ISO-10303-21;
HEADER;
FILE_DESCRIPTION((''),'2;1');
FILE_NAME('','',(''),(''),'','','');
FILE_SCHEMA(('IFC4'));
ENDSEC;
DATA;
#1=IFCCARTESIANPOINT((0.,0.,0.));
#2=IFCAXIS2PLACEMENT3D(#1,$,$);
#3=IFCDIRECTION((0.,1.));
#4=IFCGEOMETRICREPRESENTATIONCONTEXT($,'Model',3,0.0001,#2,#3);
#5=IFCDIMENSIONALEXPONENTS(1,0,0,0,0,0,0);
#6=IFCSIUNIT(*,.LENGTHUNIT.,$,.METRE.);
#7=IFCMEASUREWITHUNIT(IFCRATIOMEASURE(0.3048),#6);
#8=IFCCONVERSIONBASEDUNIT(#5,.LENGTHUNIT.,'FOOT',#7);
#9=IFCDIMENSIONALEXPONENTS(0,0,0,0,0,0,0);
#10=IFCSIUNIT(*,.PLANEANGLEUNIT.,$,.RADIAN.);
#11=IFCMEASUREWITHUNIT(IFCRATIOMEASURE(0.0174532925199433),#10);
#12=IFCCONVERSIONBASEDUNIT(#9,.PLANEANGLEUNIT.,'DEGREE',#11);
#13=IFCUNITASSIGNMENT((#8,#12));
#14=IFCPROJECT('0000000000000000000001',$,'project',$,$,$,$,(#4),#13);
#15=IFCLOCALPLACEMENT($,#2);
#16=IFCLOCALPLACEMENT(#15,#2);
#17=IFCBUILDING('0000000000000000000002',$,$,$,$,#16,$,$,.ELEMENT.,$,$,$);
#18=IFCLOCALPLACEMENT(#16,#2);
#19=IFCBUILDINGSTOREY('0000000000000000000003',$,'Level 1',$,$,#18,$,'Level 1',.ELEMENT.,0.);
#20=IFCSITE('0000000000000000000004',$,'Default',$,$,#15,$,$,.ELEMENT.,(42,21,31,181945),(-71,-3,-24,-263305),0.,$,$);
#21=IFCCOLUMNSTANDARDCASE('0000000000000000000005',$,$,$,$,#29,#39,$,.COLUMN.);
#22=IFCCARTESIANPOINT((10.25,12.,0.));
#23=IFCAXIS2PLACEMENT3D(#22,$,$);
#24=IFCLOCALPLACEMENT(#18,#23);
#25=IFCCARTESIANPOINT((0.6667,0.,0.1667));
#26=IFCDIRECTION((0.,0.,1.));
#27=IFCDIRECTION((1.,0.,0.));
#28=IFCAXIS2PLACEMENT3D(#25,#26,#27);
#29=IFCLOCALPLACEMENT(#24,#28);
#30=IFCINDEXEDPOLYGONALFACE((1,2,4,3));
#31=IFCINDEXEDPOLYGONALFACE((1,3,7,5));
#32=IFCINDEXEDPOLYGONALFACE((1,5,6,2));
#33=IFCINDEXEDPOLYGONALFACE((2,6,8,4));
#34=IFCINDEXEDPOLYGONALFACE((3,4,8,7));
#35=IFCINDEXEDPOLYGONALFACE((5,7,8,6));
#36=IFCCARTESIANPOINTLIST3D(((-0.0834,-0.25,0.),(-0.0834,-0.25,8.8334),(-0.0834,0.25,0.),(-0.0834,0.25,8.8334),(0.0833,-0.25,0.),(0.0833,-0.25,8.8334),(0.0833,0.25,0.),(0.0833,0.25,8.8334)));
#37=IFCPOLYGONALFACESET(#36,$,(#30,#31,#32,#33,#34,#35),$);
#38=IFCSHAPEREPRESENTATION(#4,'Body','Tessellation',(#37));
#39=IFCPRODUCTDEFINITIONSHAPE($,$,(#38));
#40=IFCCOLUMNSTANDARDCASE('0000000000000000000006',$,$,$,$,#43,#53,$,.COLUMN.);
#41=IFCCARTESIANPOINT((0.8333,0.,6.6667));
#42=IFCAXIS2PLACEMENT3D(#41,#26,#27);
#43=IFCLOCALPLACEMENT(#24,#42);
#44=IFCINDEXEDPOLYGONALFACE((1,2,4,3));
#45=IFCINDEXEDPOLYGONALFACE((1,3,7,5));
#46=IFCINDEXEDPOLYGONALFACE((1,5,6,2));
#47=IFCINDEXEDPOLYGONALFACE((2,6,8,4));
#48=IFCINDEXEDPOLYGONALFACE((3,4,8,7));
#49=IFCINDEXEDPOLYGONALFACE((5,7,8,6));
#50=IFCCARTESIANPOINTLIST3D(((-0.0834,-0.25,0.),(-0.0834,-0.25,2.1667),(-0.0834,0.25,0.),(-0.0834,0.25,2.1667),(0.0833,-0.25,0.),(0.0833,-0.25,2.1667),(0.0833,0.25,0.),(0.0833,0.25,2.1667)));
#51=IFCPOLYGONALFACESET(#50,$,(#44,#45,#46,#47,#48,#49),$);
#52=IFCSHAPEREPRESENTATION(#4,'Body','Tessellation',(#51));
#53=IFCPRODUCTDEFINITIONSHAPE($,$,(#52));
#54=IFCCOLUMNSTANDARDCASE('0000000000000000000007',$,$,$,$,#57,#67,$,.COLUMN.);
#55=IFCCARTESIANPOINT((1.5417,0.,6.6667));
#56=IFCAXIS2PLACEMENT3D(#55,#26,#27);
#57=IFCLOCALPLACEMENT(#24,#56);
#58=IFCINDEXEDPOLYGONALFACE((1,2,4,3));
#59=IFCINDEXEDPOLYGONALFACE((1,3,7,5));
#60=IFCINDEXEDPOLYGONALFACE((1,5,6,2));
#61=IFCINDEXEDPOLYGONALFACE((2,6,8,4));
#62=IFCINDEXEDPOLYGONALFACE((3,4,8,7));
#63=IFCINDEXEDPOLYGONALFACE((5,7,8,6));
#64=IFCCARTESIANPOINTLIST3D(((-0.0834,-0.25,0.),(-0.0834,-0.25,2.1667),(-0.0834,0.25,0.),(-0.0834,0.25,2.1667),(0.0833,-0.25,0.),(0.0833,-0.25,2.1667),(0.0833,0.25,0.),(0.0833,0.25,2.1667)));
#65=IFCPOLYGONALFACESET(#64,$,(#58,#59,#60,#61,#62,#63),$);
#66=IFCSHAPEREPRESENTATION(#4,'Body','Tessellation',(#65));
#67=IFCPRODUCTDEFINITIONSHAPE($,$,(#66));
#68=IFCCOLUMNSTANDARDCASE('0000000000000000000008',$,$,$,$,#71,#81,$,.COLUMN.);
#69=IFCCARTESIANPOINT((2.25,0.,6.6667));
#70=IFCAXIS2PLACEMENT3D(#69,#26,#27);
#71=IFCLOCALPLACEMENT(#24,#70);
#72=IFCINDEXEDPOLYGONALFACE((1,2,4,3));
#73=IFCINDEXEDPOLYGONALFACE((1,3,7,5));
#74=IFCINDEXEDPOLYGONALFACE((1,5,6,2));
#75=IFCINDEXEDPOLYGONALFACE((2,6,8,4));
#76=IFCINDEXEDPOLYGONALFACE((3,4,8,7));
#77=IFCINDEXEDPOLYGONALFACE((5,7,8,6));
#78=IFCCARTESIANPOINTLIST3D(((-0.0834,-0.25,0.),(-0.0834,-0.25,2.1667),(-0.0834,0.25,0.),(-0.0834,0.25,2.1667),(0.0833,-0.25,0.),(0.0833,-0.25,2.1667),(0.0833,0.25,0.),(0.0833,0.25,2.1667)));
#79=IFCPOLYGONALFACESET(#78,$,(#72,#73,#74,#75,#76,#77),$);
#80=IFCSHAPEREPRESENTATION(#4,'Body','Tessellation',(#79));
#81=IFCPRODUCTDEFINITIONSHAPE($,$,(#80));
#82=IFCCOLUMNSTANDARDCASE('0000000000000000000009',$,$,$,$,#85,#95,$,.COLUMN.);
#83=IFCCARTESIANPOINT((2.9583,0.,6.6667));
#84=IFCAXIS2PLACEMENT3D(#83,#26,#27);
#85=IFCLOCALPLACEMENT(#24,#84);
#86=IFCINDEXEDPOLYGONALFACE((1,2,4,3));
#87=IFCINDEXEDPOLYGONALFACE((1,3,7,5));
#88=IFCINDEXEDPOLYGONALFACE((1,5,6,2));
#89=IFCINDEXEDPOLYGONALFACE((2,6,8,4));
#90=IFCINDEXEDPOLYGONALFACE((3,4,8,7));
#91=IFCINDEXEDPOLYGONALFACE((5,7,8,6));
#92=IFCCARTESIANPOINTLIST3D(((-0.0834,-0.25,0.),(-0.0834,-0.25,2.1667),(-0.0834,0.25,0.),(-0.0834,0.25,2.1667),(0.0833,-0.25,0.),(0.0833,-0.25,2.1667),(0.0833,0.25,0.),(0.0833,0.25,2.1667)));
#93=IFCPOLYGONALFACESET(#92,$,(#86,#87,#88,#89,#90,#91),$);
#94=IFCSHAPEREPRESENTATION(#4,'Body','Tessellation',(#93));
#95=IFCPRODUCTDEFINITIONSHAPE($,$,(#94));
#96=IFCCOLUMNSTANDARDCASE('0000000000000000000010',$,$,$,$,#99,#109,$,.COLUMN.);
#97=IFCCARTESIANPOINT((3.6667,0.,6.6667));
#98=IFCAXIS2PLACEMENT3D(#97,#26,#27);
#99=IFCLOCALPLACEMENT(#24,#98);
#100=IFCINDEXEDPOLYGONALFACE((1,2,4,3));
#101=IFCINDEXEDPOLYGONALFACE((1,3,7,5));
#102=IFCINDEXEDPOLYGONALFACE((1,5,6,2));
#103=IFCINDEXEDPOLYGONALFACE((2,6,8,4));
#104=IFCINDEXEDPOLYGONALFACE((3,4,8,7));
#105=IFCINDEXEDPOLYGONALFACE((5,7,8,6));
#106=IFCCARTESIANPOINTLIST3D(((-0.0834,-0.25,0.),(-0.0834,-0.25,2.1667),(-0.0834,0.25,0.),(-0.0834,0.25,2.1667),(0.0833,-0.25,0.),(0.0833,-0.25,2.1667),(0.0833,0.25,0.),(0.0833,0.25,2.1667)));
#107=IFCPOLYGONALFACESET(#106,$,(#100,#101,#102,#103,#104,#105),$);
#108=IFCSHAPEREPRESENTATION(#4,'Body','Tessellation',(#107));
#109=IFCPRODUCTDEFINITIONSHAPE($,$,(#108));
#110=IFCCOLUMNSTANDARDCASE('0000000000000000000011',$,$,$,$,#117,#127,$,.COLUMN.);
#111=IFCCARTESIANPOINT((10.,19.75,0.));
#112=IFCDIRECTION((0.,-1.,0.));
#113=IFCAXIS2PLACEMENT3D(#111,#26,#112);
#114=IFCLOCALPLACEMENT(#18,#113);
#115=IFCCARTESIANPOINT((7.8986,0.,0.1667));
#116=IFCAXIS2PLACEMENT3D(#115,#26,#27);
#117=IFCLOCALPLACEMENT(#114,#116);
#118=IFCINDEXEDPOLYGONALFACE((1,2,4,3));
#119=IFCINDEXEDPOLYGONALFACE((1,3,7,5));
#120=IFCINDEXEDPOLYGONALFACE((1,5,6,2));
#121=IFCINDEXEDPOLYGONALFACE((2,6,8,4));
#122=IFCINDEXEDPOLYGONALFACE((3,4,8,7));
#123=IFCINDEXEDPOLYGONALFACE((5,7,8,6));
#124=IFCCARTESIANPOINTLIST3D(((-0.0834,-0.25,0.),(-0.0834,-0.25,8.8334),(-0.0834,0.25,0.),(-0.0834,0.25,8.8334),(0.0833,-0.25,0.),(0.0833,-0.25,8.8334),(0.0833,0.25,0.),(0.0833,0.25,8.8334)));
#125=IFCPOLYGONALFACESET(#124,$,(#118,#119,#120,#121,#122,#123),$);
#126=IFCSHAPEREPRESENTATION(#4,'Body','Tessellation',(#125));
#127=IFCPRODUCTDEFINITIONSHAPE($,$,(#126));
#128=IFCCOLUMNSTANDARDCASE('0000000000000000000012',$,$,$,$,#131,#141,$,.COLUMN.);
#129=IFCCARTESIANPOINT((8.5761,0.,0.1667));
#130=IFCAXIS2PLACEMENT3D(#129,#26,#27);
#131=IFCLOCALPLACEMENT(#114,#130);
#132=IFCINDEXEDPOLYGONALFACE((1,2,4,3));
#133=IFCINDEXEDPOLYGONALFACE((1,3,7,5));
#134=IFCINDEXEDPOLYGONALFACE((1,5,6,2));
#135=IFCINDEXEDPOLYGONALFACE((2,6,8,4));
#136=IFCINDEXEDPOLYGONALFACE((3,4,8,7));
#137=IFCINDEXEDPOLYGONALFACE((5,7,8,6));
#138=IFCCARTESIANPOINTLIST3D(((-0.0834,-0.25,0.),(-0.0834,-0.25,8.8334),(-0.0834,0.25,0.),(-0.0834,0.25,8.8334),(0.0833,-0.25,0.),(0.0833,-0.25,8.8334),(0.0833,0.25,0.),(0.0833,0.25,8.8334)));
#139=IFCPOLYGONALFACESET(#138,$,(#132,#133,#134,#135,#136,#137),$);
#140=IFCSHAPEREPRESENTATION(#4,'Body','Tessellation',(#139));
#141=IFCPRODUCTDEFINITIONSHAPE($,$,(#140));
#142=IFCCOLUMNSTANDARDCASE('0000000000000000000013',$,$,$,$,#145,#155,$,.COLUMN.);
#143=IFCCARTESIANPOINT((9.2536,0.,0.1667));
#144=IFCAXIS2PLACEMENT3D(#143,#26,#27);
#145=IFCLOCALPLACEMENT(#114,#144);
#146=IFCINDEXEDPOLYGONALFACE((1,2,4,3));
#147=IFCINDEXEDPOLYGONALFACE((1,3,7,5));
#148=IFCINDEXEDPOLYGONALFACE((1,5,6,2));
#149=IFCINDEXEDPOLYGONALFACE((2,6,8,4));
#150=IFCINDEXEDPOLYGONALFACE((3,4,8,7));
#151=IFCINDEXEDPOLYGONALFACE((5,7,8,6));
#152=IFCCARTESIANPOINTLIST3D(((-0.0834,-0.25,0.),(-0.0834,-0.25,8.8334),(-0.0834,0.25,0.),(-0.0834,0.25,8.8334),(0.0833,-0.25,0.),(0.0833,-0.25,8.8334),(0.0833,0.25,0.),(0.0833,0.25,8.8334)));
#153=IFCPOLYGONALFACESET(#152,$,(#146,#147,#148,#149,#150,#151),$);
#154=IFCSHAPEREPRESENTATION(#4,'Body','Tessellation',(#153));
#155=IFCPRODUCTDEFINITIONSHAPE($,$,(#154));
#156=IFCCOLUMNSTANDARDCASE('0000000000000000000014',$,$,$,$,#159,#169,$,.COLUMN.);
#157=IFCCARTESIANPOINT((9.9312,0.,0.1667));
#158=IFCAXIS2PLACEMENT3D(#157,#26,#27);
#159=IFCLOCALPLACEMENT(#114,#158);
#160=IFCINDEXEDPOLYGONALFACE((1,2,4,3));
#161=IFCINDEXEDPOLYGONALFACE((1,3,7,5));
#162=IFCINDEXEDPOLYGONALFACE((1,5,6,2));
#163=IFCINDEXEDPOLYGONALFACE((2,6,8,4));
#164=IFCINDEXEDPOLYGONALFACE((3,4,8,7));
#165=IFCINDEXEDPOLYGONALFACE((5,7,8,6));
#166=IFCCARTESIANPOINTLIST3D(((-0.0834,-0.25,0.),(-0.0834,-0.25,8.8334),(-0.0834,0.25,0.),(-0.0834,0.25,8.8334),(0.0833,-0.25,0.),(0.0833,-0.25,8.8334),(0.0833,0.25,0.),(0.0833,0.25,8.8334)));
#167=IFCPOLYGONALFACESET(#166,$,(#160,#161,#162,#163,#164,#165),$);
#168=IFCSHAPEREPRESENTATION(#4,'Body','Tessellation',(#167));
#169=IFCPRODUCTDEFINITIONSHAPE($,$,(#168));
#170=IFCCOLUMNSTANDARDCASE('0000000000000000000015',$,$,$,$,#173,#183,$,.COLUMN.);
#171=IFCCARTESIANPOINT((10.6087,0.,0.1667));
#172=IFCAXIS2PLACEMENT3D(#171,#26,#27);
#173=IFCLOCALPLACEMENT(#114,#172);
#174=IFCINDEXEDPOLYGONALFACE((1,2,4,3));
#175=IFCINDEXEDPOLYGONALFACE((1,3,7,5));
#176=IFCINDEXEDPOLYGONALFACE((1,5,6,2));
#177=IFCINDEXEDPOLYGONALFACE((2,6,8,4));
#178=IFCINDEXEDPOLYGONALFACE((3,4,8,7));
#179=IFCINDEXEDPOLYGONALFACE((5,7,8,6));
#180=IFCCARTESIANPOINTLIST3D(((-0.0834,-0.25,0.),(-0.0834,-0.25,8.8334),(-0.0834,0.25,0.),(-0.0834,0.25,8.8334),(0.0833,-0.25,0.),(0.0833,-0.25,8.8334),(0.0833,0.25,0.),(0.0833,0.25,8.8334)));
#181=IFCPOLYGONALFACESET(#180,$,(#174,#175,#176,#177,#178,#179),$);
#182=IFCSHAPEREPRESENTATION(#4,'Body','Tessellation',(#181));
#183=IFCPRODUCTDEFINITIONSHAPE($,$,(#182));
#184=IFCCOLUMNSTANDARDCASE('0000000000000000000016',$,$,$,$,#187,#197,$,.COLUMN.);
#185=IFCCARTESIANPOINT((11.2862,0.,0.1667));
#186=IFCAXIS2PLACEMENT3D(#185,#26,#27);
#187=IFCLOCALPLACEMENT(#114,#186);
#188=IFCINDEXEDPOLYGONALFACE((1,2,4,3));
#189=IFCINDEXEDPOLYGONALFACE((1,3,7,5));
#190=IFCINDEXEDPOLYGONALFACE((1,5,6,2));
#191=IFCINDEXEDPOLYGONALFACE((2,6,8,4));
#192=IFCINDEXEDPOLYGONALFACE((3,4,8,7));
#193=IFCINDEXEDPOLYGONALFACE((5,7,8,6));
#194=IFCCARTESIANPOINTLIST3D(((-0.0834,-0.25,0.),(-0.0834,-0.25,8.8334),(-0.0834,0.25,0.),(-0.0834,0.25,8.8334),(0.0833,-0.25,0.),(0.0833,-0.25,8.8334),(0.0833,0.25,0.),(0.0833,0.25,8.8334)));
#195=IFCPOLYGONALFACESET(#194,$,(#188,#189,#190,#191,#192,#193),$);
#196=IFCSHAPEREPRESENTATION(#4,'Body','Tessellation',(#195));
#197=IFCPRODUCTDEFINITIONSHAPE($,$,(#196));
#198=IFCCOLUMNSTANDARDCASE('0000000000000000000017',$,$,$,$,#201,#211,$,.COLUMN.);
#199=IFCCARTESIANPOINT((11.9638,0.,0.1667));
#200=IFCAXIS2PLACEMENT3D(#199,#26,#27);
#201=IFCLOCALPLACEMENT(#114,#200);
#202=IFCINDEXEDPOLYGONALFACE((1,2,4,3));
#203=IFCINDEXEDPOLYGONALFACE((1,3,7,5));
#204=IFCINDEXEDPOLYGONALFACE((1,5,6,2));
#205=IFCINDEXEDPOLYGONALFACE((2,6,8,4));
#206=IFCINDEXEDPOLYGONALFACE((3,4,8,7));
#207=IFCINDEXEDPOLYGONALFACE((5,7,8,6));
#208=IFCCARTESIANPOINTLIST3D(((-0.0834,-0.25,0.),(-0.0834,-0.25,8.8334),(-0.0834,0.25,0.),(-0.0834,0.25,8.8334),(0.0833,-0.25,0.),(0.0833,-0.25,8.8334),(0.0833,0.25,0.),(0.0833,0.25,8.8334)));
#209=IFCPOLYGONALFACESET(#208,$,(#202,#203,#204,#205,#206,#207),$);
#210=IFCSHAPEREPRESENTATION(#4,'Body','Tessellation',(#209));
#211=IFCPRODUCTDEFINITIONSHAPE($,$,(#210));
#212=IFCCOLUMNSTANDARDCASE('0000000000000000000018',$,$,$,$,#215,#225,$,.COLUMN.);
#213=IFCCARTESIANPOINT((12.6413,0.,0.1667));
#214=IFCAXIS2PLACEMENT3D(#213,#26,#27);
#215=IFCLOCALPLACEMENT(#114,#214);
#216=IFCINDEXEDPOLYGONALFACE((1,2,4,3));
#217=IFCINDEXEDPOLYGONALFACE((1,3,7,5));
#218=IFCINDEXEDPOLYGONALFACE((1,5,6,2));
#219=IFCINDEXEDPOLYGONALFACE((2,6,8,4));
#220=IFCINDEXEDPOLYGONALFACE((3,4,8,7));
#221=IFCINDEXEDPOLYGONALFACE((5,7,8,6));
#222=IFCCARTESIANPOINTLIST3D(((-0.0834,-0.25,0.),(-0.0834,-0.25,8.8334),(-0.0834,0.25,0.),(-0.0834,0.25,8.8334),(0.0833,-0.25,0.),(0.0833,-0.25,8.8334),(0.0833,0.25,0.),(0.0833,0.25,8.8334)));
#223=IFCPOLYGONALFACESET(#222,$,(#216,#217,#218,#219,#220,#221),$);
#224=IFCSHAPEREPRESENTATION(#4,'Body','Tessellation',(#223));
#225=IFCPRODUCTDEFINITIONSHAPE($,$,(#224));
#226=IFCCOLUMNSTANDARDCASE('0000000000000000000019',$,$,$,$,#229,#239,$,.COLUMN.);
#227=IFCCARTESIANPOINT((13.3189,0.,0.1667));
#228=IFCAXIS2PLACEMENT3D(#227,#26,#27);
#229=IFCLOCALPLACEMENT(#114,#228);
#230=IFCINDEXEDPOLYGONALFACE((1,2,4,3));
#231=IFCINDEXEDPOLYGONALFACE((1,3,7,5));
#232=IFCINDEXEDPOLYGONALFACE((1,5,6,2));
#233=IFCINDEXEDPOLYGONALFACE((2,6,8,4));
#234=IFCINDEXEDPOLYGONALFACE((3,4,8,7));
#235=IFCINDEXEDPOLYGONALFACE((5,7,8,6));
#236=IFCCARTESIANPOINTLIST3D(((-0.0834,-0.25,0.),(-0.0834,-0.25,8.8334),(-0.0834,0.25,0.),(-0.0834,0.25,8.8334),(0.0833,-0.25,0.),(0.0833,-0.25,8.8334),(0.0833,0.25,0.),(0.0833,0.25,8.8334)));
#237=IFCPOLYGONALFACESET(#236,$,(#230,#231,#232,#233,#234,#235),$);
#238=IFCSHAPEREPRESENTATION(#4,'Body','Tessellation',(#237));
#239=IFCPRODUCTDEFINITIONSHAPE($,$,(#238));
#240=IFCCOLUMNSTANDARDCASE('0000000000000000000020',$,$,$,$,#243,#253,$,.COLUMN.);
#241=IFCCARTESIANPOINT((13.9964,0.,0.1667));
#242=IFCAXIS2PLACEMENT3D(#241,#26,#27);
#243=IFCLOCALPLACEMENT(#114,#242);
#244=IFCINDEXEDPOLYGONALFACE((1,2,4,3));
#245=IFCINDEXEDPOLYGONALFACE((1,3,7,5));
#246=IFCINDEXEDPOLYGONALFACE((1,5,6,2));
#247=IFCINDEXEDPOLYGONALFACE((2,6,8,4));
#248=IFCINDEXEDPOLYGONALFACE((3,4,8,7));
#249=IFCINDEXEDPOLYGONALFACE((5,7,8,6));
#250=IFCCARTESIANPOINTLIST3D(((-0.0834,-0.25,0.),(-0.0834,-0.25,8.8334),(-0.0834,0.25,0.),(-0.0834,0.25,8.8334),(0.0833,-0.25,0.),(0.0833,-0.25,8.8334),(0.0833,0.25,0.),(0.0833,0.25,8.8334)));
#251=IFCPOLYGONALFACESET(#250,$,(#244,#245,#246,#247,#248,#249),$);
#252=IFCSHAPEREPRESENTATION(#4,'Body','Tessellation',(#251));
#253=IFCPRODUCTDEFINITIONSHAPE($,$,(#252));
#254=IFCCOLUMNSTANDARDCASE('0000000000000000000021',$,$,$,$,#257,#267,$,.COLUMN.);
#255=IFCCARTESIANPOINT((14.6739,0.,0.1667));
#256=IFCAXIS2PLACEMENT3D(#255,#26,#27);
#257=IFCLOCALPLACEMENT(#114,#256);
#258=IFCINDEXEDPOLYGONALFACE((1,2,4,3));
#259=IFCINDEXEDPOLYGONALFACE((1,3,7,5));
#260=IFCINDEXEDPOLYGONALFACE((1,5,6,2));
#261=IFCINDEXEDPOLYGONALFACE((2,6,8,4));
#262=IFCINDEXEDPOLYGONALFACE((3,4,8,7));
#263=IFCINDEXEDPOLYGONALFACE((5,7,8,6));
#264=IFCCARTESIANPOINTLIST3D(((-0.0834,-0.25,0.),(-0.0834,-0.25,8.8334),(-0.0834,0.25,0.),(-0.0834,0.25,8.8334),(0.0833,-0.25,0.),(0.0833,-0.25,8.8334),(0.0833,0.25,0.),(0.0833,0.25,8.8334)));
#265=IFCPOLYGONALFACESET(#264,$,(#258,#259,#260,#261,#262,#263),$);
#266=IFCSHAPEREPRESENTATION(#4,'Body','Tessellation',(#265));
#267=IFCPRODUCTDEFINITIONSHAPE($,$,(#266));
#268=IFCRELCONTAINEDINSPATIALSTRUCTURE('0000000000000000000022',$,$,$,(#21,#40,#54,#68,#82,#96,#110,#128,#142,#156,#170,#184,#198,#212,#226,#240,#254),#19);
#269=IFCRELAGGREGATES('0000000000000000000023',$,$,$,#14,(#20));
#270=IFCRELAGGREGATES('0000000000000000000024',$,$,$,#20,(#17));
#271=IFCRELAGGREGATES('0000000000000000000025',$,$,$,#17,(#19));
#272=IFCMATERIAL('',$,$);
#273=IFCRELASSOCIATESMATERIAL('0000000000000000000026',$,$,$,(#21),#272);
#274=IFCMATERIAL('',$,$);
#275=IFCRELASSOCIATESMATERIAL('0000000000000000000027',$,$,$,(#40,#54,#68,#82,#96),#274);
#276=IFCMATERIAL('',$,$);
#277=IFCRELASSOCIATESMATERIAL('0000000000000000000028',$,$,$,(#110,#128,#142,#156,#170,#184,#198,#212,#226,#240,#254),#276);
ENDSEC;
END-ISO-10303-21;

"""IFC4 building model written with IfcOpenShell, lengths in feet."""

from ifc_helpers import new_model, entity, si_unit, converted_unit, direction, frame, origin, place, context, project, spatial, rectangle, extrude, material, element, save


model = new_model("IFC4")

# Units and contexts
model_context = context("Model", 3, precision=0.0001, world=origin(), true_north=direction((0.0, 1.0)))
ifc_project = project(units=[converted_unit("LENGTHUNIT", "FOOT", entity("IfcRatioMeasure", 0.3048), si_unit("LENGTHUNIT", "METRE"), dimensions=[1, 0, 0, 0, 0, 0, 0]), converted_unit("PLANEANGLEUNIT", "DEGREE", entity("IfcRatioMeasure", 0.0174532925199433), si_unit("PLANEANGLEUNIT", "RADIAN"), dimensions=[0, 0, 0, 0, 0, 0, 0])], contexts=[model_context])

# Site, building, storey
site_placement = place(None, origin())
site = spatial("IfcSite", under=ifc_project, at=site_placement, Name="Default", CompositionType="ELEMENT", RefLatitude=(42, 21, 31, 181945), RefLongitude=(-71, -3, -24, -263305), RefElevation=0.0)
building_placement = place(site_placement, origin())
building = spatial("IfcBuilding", under=site, at=building_placement, CompositionType="ELEMENT")
storey_placement = place(building_placement, origin())
storey = spatial("IfcBuildingStorey", under=building, at=storey_placement, Name="Level 1", LongName="Level 1", CompositionType="ELEMENT", Elevation=0.0)

# Columns
ifc_material_1 = material(Name="")
placement_1 = place(storey_placement, frame((10.25, 12.0, 0.0)))
for number, where, z_axis, x_axis in (
    (1, (0.6667, 0.0, 0.1667), (0.0, 0.0, 1.0), (1.0, 0.0, 0.0)),
):
    element("IfcColumnStandardCase", number, at=place(placement_1, frame(where, z_axis=z_axis, x_axis=x_axis)), inside=storey, material=ifc_material_1, PredefinedType="COLUMN", context=model_context, shape_type="SweptSolid", body=[
        extrude(rectangle(XDim=0.1667, YDim=0.5), origin(), (0.0, 0.0, 1.0), 8.8334),
    ])
ifc_material_2 = material(Name="")
ifc_material_3 = material(Name="")
for number, where, z_axis, x_axis in (
    (2, (0.8333, 0.0, 6.6667), (0.0, 0.0, 1.0), (1.0, 0.0, 0.0)),
    (3, (1.5417, 0.0, 6.6667), (0.0, 0.0, 1.0), (1.0, 0.0, 0.0)),
    (4, (2.25, 0.0, 6.6667), (0.0, 0.0, 1.0), (1.0, 0.0, 0.0)),
    (5, (2.9583, 0.0, 6.6667), (0.0, 0.0, 1.0), (1.0, 0.0, 0.0)),
    (6, (3.6667, 0.0, 6.6667), (0.0, 0.0, 1.0), (1.0, 0.0, 0.0)),
):
    element("IfcColumnStandardCase", number, at=place(placement_1, frame(where, z_axis=z_axis, x_axis=x_axis)), inside=storey, material=ifc_material_3, PredefinedType="COLUMN", context=model_context, shape_type="SweptSolid", body=[
        extrude(rectangle(XDim=0.1667, YDim=0.5), origin(), (0.0, 0.0, 1.0), 2.1667),
    ])
placement_2 = place(storey_placement, frame((10.0, 19.75, 0.0), z_axis=(0.0, 0.0, 1.0), x_axis=(0.0, -1.0, 0.0)))
for number, where, z_axis, x_axis in (
    (7, (7.8986, 0.0, 0.1667), (0.0, 0.0, 1.0), (1.0, 0.0, 0.0)),
    (8, (8.5761, 0.0, 0.1667), (0.0, 0.0, 1.0), (1.0, 0.0, 0.0)),
    (9, (9.2536, 0.0, 0.1667), (0.0, 0.0, 1.0), (1.0, 0.0, 0.0)),
    (10, (9.9312, 0.0, 0.1667), (0.0, 0.0, 1.0), (1.0, 0.0, 0.0)),
    (11, (10.6087, 0.0, 0.1667), (0.0, 0.0, 1.0), (1.0, 0.0, 0.0)),
    (12, (11.2862, 0.0, 0.1667), (0.0, 0.0, 1.0), (1.0, 0.0, 0.0)),
    (13, (11.9638, 0.0, 0.1667), (0.0, 0.0, 1.0), (1.0, 0.0, 0.0)),
    (14, (12.6413, 0.0, 0.1667), (0.0, 0.0, 1.0), (1.0, 0.0, 0.0)),
    (15, (13.3189, 0.0, 0.1667), (0.0, 0.0, 1.0), (1.0, 0.0, 0.0)),
    (16, (13.9964, 0.0, 0.1667), (0.0, 0.0, 1.0), (1.0, 0.0, 0.0)),
    (17, (14.6739, 0.0, 0.1667), (0.0, 0.0, 1.0), (1.0, 0.0, 0.0)),
):
    element("IfcColumnStandardCase", number, at=place(placement_2, frame(where, z_axis=z_axis, x_axis=x_axis)), inside=storey, material=ifc_material_2, PredefinedType="COLUMN", context=model_context, shape_type="SweptSolid", body=[
        extrude(rectangle(XDim=0.1667, YDim=0.5), origin(), (0.0, 0.0, 1.0), 8.8334),
    ])

save(model, "model.ifc")
